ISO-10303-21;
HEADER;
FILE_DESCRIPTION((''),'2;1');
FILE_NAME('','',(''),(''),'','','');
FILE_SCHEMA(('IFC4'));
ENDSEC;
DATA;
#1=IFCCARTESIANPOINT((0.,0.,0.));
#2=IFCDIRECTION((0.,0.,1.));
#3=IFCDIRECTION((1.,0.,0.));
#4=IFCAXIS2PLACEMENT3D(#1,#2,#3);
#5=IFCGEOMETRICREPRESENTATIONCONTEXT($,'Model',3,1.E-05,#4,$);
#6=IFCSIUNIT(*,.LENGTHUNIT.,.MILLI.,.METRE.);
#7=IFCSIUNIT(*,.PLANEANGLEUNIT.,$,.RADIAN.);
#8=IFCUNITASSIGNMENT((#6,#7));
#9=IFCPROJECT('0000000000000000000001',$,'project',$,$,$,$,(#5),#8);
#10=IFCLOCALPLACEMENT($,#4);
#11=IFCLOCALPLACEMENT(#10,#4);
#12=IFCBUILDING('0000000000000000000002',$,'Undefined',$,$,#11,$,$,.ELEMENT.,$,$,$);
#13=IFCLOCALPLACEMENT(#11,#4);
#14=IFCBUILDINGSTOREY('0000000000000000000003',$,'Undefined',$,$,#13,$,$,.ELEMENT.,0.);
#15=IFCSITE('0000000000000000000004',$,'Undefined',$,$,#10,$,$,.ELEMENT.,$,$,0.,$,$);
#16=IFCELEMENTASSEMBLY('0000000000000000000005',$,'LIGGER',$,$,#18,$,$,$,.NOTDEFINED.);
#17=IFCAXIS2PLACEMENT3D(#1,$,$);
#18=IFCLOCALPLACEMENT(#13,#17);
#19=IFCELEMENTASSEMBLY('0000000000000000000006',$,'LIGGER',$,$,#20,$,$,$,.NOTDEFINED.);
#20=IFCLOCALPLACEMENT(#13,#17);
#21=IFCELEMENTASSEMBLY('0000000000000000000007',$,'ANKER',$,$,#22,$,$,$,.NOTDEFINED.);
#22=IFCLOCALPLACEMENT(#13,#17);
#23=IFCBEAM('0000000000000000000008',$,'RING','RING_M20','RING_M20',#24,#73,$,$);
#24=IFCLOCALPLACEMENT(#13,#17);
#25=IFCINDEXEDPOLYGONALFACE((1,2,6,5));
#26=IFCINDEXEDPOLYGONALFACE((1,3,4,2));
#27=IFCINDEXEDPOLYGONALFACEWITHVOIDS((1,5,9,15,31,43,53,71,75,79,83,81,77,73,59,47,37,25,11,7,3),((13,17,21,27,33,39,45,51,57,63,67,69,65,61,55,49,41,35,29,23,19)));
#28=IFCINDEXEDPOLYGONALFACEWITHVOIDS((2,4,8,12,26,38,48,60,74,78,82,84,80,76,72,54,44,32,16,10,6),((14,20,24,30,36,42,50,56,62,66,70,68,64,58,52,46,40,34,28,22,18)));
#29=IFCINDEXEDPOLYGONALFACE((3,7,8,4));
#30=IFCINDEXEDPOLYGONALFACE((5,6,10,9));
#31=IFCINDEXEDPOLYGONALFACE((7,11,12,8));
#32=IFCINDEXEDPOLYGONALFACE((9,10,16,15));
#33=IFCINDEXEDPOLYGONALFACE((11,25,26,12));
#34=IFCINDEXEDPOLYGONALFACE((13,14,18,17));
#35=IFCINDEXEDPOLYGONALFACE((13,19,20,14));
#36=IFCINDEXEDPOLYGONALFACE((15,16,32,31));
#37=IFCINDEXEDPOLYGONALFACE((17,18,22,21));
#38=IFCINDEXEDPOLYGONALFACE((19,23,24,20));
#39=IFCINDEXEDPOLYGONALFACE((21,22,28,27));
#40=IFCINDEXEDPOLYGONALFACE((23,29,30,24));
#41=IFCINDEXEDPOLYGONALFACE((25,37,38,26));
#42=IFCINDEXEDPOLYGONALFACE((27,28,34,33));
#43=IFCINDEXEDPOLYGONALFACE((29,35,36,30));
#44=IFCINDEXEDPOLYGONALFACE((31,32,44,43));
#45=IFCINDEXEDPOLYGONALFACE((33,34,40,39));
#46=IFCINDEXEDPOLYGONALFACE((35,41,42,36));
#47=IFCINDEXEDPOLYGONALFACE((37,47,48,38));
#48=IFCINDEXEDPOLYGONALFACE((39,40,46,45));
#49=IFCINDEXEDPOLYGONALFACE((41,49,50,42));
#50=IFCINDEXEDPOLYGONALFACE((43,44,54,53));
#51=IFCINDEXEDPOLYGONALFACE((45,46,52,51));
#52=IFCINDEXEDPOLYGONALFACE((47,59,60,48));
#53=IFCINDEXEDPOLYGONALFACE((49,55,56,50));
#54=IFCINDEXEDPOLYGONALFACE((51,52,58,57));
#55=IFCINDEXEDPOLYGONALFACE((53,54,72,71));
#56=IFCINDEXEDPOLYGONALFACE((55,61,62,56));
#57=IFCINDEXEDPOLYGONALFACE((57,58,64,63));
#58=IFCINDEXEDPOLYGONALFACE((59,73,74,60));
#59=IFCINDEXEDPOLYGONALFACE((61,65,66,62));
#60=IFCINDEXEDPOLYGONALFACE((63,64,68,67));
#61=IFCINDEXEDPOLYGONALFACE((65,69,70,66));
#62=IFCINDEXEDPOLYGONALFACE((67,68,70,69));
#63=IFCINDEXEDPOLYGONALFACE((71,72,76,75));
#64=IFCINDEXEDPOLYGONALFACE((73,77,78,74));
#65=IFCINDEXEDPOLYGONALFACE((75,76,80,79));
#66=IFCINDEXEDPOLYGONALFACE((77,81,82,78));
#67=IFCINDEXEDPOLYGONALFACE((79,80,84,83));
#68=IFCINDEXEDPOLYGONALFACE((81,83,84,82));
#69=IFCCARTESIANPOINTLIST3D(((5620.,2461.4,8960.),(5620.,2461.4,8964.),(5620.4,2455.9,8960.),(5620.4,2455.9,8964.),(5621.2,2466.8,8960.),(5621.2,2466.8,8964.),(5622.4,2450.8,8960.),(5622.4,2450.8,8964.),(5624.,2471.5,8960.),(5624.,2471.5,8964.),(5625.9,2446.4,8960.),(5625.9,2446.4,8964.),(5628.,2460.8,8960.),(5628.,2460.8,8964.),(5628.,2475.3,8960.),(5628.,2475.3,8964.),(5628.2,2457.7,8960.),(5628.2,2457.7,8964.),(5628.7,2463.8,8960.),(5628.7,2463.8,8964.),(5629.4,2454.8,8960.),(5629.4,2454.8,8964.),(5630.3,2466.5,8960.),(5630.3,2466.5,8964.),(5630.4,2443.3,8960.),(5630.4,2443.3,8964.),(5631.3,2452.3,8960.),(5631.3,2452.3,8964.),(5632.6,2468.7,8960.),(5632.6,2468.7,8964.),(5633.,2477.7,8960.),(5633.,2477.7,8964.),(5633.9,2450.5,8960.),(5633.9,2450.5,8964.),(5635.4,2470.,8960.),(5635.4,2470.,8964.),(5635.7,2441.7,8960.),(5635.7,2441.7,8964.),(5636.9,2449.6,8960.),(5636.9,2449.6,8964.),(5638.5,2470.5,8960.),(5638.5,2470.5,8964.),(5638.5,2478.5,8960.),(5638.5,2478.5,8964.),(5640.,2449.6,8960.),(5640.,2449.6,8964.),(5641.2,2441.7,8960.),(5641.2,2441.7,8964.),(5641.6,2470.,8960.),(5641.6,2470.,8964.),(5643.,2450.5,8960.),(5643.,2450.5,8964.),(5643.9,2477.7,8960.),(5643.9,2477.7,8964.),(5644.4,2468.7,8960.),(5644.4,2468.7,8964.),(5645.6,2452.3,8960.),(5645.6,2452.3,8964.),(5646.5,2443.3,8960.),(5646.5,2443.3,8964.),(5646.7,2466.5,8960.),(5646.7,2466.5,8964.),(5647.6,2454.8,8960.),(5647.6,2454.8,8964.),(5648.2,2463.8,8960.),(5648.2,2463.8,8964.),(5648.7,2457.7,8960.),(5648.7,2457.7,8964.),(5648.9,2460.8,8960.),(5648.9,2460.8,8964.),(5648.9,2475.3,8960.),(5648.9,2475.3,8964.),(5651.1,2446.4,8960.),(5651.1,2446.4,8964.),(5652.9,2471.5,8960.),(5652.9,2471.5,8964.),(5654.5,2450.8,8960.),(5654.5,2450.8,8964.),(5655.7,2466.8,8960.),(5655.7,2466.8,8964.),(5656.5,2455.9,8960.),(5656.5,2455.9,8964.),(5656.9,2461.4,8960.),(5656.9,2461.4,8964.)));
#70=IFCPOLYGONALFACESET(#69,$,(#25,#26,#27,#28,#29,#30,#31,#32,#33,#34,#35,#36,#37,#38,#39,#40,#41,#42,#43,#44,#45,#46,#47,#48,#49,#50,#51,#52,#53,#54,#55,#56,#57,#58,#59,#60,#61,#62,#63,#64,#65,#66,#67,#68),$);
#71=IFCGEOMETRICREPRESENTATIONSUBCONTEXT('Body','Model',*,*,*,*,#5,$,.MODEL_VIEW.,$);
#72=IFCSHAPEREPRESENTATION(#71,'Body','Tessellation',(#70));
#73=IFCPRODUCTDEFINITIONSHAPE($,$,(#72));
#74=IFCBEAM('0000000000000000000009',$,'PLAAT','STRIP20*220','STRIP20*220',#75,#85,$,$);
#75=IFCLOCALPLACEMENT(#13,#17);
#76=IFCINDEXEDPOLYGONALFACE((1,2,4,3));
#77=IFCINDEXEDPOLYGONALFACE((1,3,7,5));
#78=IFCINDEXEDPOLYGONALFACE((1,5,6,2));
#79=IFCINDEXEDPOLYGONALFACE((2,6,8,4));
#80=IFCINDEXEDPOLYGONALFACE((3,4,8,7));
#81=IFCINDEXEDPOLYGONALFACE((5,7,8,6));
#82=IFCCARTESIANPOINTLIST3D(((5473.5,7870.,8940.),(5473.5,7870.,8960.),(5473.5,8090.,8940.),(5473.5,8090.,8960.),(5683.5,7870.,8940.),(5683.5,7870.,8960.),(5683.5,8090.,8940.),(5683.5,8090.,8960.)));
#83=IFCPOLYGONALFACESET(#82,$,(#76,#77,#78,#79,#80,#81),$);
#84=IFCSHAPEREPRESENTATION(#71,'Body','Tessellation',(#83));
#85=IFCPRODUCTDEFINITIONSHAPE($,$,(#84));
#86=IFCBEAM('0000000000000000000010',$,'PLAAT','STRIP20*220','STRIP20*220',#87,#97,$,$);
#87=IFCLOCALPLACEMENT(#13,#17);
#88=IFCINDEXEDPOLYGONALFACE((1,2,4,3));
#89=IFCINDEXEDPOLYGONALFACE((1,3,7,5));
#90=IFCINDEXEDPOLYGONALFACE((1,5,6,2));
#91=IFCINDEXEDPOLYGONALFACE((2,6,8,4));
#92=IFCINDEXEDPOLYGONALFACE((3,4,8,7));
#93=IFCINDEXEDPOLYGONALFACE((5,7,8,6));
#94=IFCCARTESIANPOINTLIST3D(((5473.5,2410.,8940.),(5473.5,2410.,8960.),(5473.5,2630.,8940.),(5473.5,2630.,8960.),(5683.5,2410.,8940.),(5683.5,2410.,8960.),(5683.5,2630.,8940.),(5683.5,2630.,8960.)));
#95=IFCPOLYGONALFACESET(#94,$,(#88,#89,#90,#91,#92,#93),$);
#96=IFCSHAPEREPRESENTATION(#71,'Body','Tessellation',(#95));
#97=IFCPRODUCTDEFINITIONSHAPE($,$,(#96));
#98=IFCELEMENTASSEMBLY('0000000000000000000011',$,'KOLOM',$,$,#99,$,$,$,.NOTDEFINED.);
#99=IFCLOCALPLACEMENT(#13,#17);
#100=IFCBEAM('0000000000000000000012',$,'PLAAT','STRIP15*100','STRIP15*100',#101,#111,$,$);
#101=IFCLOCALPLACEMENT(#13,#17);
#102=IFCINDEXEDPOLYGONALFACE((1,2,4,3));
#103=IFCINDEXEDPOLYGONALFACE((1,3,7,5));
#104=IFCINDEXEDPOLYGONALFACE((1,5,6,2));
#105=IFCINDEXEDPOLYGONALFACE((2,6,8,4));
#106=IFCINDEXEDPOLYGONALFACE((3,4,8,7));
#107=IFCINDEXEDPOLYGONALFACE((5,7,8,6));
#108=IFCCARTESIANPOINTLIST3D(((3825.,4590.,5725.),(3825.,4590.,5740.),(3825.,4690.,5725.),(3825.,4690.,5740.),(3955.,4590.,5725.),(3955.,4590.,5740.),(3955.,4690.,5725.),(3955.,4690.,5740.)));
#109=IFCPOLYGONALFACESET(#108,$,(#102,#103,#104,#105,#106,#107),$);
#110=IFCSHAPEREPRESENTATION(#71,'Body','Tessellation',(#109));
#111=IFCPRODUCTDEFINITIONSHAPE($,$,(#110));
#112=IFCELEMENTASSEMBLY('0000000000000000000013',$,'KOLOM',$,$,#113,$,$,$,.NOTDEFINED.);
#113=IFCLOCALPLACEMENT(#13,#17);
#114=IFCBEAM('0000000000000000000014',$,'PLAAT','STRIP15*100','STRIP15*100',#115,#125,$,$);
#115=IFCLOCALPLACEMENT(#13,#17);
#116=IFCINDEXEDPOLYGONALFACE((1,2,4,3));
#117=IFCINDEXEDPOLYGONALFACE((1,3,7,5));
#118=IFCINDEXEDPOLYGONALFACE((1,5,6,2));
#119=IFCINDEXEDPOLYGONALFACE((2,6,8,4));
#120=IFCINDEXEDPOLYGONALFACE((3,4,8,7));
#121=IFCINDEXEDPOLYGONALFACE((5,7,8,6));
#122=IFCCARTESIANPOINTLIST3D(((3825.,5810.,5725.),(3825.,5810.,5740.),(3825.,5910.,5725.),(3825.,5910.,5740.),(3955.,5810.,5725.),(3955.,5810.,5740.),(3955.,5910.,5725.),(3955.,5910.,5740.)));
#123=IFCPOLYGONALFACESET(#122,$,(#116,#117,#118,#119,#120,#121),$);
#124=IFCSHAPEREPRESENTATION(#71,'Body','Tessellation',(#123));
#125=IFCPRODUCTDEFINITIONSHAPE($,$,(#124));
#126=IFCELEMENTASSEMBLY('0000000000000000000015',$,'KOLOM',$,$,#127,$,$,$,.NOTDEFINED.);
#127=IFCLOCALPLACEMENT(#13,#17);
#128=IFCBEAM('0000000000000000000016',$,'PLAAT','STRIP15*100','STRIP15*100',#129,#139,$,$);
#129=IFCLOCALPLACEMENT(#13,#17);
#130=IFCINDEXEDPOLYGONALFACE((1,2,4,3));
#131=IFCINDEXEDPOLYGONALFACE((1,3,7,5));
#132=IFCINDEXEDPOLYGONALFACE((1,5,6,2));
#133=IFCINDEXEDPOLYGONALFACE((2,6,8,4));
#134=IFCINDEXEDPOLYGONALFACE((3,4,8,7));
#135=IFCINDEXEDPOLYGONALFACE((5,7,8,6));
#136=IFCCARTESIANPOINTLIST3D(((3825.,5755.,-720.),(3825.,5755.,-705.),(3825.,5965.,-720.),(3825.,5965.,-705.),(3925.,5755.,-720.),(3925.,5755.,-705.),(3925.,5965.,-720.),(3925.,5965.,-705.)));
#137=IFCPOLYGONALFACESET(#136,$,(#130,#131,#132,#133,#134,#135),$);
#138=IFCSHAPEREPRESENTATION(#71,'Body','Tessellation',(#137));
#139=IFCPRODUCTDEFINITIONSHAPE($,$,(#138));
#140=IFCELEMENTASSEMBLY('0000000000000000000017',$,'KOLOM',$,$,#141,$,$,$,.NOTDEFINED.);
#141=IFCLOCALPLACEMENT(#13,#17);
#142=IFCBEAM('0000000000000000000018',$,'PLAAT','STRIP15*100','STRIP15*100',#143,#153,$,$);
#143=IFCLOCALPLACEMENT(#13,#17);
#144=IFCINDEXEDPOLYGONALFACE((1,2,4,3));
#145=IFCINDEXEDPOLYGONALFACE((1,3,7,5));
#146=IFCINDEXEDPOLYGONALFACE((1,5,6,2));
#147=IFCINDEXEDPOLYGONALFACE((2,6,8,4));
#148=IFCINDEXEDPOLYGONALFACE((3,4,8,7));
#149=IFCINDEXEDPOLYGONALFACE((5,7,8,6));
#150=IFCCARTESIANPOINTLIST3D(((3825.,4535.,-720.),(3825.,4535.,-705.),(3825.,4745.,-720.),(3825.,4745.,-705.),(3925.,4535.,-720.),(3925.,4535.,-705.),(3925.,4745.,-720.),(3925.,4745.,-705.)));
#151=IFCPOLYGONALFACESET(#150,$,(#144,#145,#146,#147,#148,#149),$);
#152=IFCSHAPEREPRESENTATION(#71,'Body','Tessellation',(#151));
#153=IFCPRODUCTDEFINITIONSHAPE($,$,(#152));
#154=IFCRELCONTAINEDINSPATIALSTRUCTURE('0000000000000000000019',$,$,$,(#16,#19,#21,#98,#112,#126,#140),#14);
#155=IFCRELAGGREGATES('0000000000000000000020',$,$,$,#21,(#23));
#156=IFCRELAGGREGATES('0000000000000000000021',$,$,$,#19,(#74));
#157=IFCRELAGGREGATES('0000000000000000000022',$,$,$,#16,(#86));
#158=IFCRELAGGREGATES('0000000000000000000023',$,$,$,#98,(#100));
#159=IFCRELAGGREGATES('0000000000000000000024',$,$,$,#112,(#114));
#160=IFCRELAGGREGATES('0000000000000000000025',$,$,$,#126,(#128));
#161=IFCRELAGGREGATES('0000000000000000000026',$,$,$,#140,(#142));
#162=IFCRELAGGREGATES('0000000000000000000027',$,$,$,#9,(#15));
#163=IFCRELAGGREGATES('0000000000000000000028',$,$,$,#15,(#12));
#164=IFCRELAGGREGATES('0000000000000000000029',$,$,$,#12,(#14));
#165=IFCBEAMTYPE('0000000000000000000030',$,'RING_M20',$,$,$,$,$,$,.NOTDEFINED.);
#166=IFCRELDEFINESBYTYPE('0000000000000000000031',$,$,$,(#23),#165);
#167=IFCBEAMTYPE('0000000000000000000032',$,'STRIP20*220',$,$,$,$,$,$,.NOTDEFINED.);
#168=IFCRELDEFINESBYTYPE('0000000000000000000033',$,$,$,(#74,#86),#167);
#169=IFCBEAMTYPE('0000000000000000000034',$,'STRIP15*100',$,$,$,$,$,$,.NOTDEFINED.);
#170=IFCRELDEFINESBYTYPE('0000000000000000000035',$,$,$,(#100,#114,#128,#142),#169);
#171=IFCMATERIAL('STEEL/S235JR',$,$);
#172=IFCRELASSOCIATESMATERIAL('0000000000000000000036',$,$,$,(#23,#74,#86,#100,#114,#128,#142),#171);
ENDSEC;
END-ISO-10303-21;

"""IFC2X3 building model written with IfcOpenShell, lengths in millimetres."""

from ifc_helpers import new_model, si_unit, frame, origin_with_axes, origin_2d_with_axis, place, context, subcontext, project, spatial, rectangle, hollow_circle, extrude, material, type_object, element, aggregate, save


model = new_model("IFC2X3")

# Units and contexts
model_context = context("Model", 3, precision=1e-05, world=origin_with_axes())
body_context = subcontext(model_context, "Body", "Model", "MODEL_VIEW")
ifc_project = project(units=[si_unit("LENGTHUNIT", "METRE", prefix="MILLI"), si_unit("PLANEANGLEUNIT", "RADIAN")], contexts=[model_context])

# Site, building, storey
site_placement = place(None, origin_with_axes())
site = spatial("IfcSite", under=ifc_project, at=site_placement, Name="Undefined", CompositionType="ELEMENT", RefElevation=0.0)
building_placement = place(site_placement, origin_with_axes())
building = spatial("IfcBuilding", under=site, at=building_placement, Name="Undefined", CompositionType="ELEMENT")
storey_placement = place(building_placement, origin_with_axes())
storey = spatial("IfcBuildingStorey", under=building, at=storey_placement, Name="Undefined", CompositionType="ELEMENT", Elevation=0.0)

# Element assemblies
ifc_material = material(Name="STEEL/S235JR")
assembly_1_placement = place(storey_placement, frame((5568.2, 2520.0, 9192.5), z_axis=(-0.906308, 0.0, 0.422618), x_axis=(0.422618, 0.0, 0.906308)))
assembly_1 = element("IfcElementAssembly", 1, at=assembly_1_placement, inside=storey, Name="LIGGER", PredefinedType="NOTDEFINED")
assembly_2_placement = place(storey_placement, frame((5568.2, 7980.0, 9192.5), z_axis=(-0.906308, 0.0, 0.422618), x_axis=(0.422618, 0.0, 0.906308)))
assembly_2 = element("IfcElementAssembly", 2, at=assembly_2_placement, inside=storey, Name="LIGGER", PredefinedType="NOTDEFINED")

# Shared definitions
beam_type_1 = type_object("IfcBeamType", Name="RING_M20", PredefinedType="NOTDEFINED")

# Element assembly, beam
assembly_3_placement = place(storey_placement, frame((5638.5, 2460.0, 9010.0), z_axis=(0.0, 1.0, 0.0), x_axis=(0.0, 0.0, -1.0)))
assembly_3 = element("IfcElementAssembly", 3, at=assembly_3_placement, inside=storey, Name="ANKER", PredefinedType="NOTDEFINED")
beam_1_placement = place(storey_placement, frame((5638.5, 2460.0, 8964.0), z_axis=(-1.0, 0.0, 0.0), x_axis=(0.0, 0.0, -1.0)))
beam_1 = element("IfcBeam", 4, at=beam_1_placement, type_object=beam_type_1, material=ifc_material, Name="RING", Description="RING_M20", ObjectType="RING_M20", context=body_context, shape_type="SweptSolid", body=[
    extrude(hollow_circle(Radius=18.5, WallThickness=8.0, at=origin_2d_with_axis()), frame((4.0, 0.0, 0.0), z_axis=(-1.0, 0.0, 0.0), x_axis=(0.0, -1.0, 0.0)), (0.0, 0.0, 1.0), 4.0),
])
aggregate(assembly_3, [beam_1])

# Beams
beam_type_2 = type_object("IfcBeamType", Name="STRIP20*220", PredefinedType="NOTDEFINED")
beam_2_placement = place(storey_placement, frame((5473.5, 7980.0, 8950.0), z_axis=(0.0, 1.0, 0.0), x_axis=(1.0, 0.0, 0.0)))
beam_2 = element("IfcBeam", 5, at=beam_2_placement, type_object=beam_type_2, material=ifc_material, Name="PLAAT", Description="STRIP20*220", ObjectType="STRIP20*220", context=body_context, shape_type="SweptSolid", body=[
    extrude(rectangle(XDim=20.0, YDim=220.0, at=origin_2d_with_axis()), frame((210.0, 0.0, 0.0), z_axis=(-1.0, 0.0, 0.0), x_axis=(0.0, -1.0, 0.0)), (0.0, 0.0, 1.0), 210.0),
])
aggregate(assembly_2, [beam_2])
beam_3_placement = place(storey_placement, frame((5473.5, 2520.0, 8950.0), z_axis=(0.0, 1.0, 0.0), x_axis=(1.0, 0.0, 0.0)))
beam_3 = element("IfcBeam", 6, at=beam_3_placement, type_object=beam_type_2, material=ifc_material, Name="PLAAT", Description="STRIP20*220", ObjectType="STRIP20*220", context=body_context, shape_type="SweptSolid", body=[
    extrude(rectangle(XDim=20.0, YDim=220.0, at=origin_2d_with_axis()), frame((210.0, 0.0, 0.0), z_axis=(-1.0, 0.0, 0.0), x_axis=(0.0, -1.0, 0.0)), (0.0, 0.0, 1.0), 210.0),
])
aggregate(assembly_1, [beam_3])

# Element assemblies, beams
assembly_4_placement = place(storey_placement, frame((3875.0, 4640.0, 3000.0), z_axis=(-1.0, 0.0, 0.0), x_axis=(0.0, 0.0, 1.0)))
assembly_4 = element("IfcElementAssembly", 7, at=assembly_4_placement, inside=storey, Name="KOLOM", PredefinedType="NOTDEFINED")
beam_type_3 = type_object("IfcBeamType", Name="STRIP15*100", PredefinedType="NOTDEFINED")
beam_4_placement = place(storey_placement, frame((3825.0, 4640.0, 5732.5), z_axis=(0.0, -1.0, 0.0), x_axis=(1.0, 0.0, 0.0)))
beam_4 = element("IfcBeam", 8, at=beam_4_placement, type_object=beam_type_3, material=ifc_material, Name="PLAAT", Description="STRIP15*100", ObjectType="STRIP15*100", context=body_context, shape_type="SweptSolid", body=[
    extrude(rectangle(XDim=15.0, YDim=100.0, at=origin_2d_with_axis()), frame((130.0, 0.0, 0.0), z_axis=(-1.0, 0.0, 0.0), x_axis=(0.0, -1.0, 0.0)), (0.0, 0.0, 1.0), 130.0),
])
aggregate(assembly_4, [beam_4])
assembly_5_placement = place(storey_placement, frame((3875.0, 5860.0, 3000.0), z_axis=(-1.0, 0.0, 0.0), x_axis=(0.0, 0.0, 1.0)))
assembly_5 = element("IfcElementAssembly", 9, at=assembly_5_placement, inside=storey, Name="KOLOM", PredefinedType="NOTDEFINED")
beam_5_placement = place(storey_placement, frame((3825.0, 5860.0, 5732.5), z_axis=(0.0, -1.0, 0.0), x_axis=(1.0, 0.0, 0.0)))
beam_5 = element("IfcBeam", 10, at=beam_5_placement, type_object=beam_type_3, material=ifc_material, Name="PLAAT", Description="STRIP15*100", ObjectType="STRIP15*100", context=body_context, shape_type="SweptSolid", body=[
    extrude(rectangle(XDim=15.0, YDim=100.0, at=origin_2d_with_axis()), frame((130.0, 0.0, 0.0), z_axis=(-1.0, 0.0, 0.0), x_axis=(0.0, -1.0, 0.0)), (0.0, 0.0, 1.0), 130.0),
])
aggregate(assembly_5, [beam_5])
assembly_6_placement = place(storey_placement, frame((3875.0, 5860.0, -750.0), z_axis=(-1.0, 0.0, 0.0), x_axis=(0.0, 0.0, 1.0)))
assembly_6 = element("IfcElementAssembly", 11, at=assembly_6_placement, inside=storey, Name="KOLOM", PredefinedType="NOTDEFINED")
beam_6_placement = place(storey_placement, frame((3925.0, 5860.0, -712.5), z_axis=(0.0, -1.0, 0.0), x_axis=(-1.0, 0.0, 0.0)))
beam_6 = element("IfcBeam", 12, at=beam_6_placement, type_object=beam_type_3, material=ifc_material, Name="PLAAT", Description="STRIP15*100", ObjectType="STRIP15*100", context=body_context, shape_type="SweptSolid", body=[
    extrude(rectangle(XDim=15.0, YDim=210.0, at=origin_2d_with_axis()), frame((100.0, 0.0, 0.0), z_axis=(-1.0, 0.0, 0.0), x_axis=(0.0, -1.0, 0.0)), (0.0, 0.0, 1.0), 100.0),
])
aggregate(assembly_6, [beam_6])
assembly_7_placement = place(storey_placement, frame((3875.0, 4640.0, -750.0), z_axis=(-1.0, 0.0, 0.0), x_axis=(0.0, 0.0, 1.0)))
assembly_7 = element("IfcElementAssembly", 13, at=assembly_7_placement, inside=storey, Name="KOLOM", PredefinedType="NOTDEFINED")
beam_7_placement = place(storey_placement, frame((3925.0, 4640.0, -712.5), z_axis=(0.0, -1.0, 0.0), x_axis=(-1.0, 0.0, 0.0)))
beam_7 = element("IfcBeam", 14, at=beam_7_placement, type_object=beam_type_3, material=ifc_material, Name="PLAAT", Description="STRIP15*100", ObjectType="STRIP15*100", context=body_context, shape_type="SweptSolid", body=[
    extrude(rectangle(XDim=15.0, YDim=210.0, at=origin_2d_with_axis()), frame((100.0, 0.0, 0.0), z_axis=(-1.0, 0.0, 0.0), x_axis=(0.0, -1.0, 0.0)), (0.0, 0.0, 1.0), 100.0),
])
aggregate(assembly_7, [beam_7])

save(model, "model.ifc")
